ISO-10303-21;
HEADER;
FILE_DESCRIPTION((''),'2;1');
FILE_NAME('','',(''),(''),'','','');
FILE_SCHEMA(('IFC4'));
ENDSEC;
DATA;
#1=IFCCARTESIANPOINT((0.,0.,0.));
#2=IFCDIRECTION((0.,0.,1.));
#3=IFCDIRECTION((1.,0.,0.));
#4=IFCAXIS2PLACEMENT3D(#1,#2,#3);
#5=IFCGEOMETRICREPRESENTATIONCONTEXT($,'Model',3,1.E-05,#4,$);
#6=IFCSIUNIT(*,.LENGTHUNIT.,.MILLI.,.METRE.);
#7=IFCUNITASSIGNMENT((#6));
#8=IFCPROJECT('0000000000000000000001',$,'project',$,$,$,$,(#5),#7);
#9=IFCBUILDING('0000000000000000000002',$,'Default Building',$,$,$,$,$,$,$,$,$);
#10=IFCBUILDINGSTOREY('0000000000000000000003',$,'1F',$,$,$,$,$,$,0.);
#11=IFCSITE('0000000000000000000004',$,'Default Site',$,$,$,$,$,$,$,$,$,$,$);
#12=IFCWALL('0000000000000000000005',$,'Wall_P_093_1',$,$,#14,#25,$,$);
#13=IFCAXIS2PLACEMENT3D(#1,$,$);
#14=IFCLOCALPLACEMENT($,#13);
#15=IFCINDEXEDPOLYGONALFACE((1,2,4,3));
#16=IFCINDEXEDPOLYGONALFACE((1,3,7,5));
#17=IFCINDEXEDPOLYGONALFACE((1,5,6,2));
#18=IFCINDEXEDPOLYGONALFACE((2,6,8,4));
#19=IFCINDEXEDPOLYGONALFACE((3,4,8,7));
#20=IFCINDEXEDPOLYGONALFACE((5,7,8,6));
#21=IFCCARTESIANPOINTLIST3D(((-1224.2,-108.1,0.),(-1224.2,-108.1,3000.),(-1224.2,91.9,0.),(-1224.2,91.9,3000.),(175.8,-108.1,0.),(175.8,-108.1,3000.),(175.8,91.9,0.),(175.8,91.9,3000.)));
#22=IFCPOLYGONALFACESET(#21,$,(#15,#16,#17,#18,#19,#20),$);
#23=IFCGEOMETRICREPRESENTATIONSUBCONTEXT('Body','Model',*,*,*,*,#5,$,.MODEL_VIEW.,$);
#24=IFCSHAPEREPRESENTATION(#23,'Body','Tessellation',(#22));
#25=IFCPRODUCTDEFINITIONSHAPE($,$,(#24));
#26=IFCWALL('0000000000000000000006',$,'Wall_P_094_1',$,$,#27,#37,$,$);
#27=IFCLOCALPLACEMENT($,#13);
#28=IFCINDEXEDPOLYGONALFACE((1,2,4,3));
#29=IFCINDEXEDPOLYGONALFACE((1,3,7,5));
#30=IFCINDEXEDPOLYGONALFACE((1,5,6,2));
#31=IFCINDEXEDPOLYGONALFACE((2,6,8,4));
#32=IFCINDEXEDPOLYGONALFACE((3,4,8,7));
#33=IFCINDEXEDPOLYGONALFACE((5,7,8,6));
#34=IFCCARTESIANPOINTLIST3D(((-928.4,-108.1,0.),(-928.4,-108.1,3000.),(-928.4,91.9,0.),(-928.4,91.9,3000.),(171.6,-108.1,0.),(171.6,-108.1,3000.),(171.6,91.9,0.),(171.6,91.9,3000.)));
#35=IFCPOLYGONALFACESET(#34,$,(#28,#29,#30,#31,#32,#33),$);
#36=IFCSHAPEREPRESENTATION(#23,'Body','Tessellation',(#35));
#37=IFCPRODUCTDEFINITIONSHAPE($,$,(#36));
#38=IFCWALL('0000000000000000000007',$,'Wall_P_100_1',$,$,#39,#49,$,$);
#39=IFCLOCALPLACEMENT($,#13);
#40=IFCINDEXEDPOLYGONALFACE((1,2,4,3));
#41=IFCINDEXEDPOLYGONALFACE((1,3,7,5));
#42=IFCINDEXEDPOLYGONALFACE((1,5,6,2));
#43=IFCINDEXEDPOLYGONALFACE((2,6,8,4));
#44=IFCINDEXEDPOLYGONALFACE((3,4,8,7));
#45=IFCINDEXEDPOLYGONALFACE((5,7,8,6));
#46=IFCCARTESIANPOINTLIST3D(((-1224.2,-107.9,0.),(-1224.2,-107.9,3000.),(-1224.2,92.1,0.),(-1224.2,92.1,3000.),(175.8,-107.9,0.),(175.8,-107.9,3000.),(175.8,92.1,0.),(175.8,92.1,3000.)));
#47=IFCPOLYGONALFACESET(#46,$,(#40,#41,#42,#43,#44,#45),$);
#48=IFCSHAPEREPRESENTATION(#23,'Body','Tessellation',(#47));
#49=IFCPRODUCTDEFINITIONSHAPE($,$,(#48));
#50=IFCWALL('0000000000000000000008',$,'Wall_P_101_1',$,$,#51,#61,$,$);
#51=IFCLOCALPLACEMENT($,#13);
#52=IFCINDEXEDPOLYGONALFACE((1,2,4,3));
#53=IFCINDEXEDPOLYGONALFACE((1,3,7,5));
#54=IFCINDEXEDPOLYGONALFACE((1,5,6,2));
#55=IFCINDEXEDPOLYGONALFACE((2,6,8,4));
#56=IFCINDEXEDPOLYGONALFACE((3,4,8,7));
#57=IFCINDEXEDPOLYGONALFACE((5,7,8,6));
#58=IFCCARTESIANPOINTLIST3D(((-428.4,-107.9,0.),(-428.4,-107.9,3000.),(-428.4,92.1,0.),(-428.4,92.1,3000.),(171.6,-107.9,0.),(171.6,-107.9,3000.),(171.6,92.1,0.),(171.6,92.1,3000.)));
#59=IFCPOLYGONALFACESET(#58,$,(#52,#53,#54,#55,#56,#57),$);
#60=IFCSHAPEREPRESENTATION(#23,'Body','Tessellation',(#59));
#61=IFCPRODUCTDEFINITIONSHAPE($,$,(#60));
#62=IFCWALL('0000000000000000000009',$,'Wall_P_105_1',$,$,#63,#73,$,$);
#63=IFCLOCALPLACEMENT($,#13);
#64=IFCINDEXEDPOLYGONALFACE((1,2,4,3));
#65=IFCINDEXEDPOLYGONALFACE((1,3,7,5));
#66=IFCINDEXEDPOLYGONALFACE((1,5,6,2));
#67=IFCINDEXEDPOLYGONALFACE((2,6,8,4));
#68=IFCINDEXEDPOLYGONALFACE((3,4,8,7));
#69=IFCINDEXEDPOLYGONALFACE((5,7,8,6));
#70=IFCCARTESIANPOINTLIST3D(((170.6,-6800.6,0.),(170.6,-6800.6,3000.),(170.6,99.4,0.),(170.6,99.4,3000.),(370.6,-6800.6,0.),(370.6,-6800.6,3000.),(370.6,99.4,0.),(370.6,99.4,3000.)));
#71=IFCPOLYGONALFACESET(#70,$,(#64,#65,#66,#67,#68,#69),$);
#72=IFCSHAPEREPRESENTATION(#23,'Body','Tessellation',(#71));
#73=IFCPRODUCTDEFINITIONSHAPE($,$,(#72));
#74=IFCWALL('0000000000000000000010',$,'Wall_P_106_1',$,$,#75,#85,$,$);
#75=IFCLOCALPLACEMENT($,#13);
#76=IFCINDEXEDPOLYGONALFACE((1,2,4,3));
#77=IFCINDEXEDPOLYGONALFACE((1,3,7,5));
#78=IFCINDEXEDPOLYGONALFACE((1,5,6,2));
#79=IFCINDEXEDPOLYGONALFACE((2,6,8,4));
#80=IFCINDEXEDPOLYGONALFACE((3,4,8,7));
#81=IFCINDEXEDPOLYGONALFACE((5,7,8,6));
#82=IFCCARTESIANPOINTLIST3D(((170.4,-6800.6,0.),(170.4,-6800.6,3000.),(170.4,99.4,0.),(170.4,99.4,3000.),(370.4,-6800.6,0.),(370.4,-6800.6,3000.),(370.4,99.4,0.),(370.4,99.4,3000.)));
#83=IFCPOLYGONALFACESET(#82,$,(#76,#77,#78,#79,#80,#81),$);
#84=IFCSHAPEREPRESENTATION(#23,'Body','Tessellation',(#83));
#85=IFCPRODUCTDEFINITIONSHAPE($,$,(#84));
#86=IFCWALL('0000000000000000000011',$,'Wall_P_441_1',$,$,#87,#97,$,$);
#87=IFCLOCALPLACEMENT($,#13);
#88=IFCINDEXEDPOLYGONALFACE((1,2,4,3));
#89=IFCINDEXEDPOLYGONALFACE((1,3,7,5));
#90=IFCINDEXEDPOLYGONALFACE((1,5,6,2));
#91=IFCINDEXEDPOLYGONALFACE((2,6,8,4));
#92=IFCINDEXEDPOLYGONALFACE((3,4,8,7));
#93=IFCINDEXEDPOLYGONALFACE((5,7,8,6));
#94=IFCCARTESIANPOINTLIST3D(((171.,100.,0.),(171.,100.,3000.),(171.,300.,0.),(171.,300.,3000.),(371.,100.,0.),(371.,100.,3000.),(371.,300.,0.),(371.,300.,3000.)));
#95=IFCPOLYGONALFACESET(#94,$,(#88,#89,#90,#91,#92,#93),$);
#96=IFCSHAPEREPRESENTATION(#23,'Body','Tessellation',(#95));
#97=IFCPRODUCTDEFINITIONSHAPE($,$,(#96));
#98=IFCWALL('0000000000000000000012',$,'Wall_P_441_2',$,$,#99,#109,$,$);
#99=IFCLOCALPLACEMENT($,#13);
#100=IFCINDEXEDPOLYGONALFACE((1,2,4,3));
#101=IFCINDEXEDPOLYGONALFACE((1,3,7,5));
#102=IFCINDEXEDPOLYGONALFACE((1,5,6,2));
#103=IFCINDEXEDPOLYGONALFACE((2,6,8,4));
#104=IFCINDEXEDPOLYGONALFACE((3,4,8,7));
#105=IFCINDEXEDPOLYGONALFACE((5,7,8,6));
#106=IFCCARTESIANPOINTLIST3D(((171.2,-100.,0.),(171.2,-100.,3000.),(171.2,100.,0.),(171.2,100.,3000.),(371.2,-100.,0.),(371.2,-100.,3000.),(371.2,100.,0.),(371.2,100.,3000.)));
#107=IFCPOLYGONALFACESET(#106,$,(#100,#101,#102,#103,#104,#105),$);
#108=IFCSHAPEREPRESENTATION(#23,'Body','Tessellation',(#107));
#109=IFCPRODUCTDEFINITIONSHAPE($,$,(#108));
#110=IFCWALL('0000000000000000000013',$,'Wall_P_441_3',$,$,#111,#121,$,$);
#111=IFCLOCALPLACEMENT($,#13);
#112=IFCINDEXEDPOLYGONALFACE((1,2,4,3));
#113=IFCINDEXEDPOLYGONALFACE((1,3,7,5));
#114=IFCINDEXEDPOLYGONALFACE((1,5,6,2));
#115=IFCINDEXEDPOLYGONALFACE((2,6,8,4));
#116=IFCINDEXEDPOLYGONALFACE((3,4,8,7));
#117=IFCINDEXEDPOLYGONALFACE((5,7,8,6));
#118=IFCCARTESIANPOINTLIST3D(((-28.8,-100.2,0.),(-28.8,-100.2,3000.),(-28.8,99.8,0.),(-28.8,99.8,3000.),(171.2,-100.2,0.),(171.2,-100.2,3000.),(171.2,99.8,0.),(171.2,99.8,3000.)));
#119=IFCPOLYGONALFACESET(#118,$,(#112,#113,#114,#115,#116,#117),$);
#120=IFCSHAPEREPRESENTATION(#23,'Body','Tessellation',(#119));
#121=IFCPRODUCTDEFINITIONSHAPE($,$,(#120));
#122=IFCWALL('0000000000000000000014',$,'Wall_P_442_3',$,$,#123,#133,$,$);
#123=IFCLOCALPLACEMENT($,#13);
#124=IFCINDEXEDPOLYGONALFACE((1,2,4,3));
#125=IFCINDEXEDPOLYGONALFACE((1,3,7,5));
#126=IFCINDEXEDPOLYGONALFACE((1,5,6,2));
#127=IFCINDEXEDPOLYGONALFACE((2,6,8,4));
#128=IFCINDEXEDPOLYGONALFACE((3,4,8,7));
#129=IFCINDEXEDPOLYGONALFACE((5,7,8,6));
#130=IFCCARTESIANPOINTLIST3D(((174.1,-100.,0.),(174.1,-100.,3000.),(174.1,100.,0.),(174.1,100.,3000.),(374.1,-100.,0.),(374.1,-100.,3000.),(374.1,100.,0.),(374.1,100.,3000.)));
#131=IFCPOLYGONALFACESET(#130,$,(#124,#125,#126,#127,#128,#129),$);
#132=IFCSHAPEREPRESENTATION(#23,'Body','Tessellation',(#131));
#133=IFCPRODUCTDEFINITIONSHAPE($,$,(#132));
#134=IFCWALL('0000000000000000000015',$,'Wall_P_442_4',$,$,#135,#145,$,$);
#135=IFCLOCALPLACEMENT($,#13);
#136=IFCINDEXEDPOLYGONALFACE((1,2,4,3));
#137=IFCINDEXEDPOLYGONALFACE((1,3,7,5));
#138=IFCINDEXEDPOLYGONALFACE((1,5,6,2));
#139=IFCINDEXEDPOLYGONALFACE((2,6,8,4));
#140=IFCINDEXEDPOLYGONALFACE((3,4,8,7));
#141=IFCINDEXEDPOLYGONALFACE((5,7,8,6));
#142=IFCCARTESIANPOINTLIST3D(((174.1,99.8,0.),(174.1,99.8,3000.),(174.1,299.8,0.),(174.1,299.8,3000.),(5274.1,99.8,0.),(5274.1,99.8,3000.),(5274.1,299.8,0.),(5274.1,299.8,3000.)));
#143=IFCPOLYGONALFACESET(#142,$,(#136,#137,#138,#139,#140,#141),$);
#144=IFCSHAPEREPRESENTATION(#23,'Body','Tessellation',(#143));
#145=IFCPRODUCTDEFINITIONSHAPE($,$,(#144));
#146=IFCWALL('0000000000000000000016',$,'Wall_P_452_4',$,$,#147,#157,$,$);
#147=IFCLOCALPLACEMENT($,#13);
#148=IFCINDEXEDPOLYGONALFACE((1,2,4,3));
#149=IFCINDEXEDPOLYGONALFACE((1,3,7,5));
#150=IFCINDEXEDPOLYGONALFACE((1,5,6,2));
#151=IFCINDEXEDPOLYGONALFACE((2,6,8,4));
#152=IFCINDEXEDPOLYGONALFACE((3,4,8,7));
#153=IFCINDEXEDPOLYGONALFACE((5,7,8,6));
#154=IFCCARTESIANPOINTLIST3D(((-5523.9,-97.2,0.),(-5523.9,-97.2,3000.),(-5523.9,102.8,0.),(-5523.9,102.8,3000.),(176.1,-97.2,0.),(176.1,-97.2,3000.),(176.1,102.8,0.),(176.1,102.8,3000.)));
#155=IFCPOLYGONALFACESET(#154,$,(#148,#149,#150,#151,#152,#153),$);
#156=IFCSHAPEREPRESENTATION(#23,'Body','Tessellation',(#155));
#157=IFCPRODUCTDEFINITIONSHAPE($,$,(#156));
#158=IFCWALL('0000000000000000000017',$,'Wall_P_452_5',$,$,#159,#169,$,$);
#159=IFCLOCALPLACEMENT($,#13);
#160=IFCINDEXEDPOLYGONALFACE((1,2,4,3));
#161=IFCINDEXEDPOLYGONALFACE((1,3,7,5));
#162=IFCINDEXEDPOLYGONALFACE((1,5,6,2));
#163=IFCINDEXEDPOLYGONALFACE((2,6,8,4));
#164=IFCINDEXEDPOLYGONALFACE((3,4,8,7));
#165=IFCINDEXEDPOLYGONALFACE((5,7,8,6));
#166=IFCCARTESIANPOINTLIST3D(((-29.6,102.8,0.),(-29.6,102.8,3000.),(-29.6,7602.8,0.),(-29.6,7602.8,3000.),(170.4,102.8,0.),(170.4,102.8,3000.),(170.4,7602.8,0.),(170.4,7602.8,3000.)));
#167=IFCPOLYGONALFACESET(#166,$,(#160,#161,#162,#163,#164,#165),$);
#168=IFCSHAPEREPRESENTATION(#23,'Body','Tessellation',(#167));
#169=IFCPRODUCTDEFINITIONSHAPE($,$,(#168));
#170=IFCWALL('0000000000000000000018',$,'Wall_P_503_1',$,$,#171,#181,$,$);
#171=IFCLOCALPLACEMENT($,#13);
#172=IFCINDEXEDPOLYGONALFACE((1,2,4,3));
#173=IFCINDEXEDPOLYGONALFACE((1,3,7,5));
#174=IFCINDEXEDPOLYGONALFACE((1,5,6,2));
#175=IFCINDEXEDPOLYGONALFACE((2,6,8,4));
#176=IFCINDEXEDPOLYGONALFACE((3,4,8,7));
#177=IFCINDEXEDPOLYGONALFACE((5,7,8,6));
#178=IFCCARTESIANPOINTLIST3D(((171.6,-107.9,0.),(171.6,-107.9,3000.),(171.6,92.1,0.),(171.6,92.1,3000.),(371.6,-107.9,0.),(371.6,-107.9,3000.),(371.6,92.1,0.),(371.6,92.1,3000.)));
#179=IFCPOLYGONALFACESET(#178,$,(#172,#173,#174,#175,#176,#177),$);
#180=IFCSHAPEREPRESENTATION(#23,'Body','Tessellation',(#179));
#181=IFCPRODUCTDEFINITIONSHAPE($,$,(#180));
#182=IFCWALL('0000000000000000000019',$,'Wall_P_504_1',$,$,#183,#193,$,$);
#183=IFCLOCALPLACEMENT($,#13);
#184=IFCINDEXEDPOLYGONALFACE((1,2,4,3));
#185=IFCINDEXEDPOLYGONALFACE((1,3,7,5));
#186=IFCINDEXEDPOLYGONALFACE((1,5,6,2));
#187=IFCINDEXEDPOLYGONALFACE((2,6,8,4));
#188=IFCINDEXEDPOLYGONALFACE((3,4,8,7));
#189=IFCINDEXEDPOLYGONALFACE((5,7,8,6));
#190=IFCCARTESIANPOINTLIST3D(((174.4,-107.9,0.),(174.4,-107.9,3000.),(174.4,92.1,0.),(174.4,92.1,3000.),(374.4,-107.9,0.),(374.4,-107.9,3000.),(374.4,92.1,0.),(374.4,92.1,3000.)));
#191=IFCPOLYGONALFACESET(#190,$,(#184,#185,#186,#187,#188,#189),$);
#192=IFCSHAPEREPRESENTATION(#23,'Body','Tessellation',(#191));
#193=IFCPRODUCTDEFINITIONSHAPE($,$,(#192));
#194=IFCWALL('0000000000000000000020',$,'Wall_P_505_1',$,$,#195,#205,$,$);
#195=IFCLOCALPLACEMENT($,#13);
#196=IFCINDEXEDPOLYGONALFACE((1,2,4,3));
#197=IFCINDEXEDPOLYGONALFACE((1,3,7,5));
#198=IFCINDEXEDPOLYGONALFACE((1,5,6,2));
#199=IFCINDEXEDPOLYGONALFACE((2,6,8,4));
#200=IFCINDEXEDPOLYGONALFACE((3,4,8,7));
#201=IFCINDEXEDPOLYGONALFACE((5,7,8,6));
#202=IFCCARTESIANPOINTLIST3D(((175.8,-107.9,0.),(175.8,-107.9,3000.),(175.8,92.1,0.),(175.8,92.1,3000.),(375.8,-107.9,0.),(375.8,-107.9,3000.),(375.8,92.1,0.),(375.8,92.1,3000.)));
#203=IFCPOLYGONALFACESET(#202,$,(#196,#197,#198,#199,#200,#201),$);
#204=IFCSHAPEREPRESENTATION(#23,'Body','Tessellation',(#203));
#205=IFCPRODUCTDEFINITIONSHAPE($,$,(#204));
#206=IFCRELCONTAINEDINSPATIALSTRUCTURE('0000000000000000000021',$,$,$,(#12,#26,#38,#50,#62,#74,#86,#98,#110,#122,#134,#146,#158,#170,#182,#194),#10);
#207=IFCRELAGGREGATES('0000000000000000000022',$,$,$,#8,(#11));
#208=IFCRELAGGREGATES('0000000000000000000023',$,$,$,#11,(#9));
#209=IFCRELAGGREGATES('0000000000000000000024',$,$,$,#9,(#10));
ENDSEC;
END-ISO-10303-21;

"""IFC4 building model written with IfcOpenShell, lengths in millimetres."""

from ifc_helpers import new_model, si_unit, frame, origin_with_axes, place, context, subcontext, project, spatial, indexed_curve, outline, extrude, element, save


model = new_model("IFC4")

# Units and contexts
model_context = context("Model", 3, precision=1e-05, world=origin_with_axes())
body_context = subcontext(model_context, "Body", "Model", "MODEL_VIEW")
ifc_project = project(units=[si_unit("LENGTHUNIT", "METRE", prefix="MILLI")], contexts=[model_context])

# Site, building, storey
site = spatial("IfcSite", under=ifc_project, Name="Default Site")
building = spatial("IfcBuilding", under=site, Name="Default Building")
storey = spatial("IfcBuildingStorey", under=building, Name="1F", Elevation=0.0)

# Walls
wall_1_placement = place(None, frame((175.8, 91.9, 0.0), z_axis=(0.0, 0.0, 1.0), x_axis=(-1.0, 0.0, 0.0)))
element("IfcWall", 1, at=wall_1_placement, inside=storey, Name="Wall_P_093_1", context=body_context, shape_type="SweptSolid", body=[
    extrude(outline(indexed_curve([(0.0, 0.0), (0.0, 200.0), (1400.0, 200.0), (1400.0, 0.0), (0.0, 0.0)], self_intersect=False)), origin_with_axes(), (0.0, 0.0, 1.0), 3000.0),
])
wall_2_placement = place(None, frame((171.6, 91.9, 0.0), z_axis=(0.0, 0.0, 1.0), x_axis=(-1.0, 0.0, 0.0)))
element("IfcWall", 2, at=wall_2_placement, inside=storey, Name="Wall_P_094_1", context=body_context, shape_type="SweptSolid", body=[
    extrude(outline(indexed_curve([(0.0, 0.0), (0.0, 200.0), (1100.0, 200.0), (1100.0, 0.0), (0.0, 0.0)], self_intersect=False)), origin_with_axes(), (0.0, 0.0, 1.0), 3000.0),
])
wall_3_placement = place(None, frame((175.8, 92.1, 0.0), z_axis=(0.0, 0.0, 1.0), x_axis=(-1.0, 0.0, 0.0)))
element("IfcWall", 3, at=wall_3_placement, inside=storey, Name="Wall_P_100_1", context=body_context, shape_type="SweptSolid", body=[
    extrude(outline(indexed_curve([(0.0, 0.0), (0.0, 200.0), (1400.0, 200.0), (1400.0, 0.0), (0.0, 0.0)], self_intersect=False)), origin_with_axes(), (0.0, 0.0, 1.0), 3000.0),
])
wall_4_placement = place(None, frame((171.6, 92.1, 0.0), z_axis=(0.0, 0.0, 1.0), x_axis=(-1.0, 0.0, 0.0)))
element("IfcWall", 4, at=wall_4_placement, inside=storey, Name="Wall_P_101_1", context=body_context, shape_type="SweptSolid", body=[
    extrude(outline(indexed_curve([(0.0, 0.0), (0.0, 200.0), (600.0, 200.0), (600.0, 0.0), (0.0, 0.0)], self_intersect=False)), origin_with_axes(), (0.0, 0.0, 1.0), 3000.0),
])
for number, where, z_axis, x_axis, name in (
    (5, (170.6, 99.4, 0.0), (0.0, 0.0, 1.0), (0.0, -1.0, 0.0), "Wall_P_105_1"),
    (6, (170.4, 99.4, 0.0), (0.0, 0.0, 1.0), (0.0, -1.0, 0.0), "Wall_P_106_1"),
):
    element("IfcWall", number, at=place(None, frame(where, z_axis=z_axis, x_axis=x_axis)), inside=storey, Name=name, context=body_context, shape_type="SweptSolid", body=[
        extrude(outline(indexed_curve([(0.0, 0.0), (0.0, 200.0), (6900.0, 200.0), (6900.0, 0.0), (0.0, 0.0)], self_intersect=False)), origin_with_axes(), (0.0, 0.0, 1.0), 3000.0),
    ])
wall_5_placement = place(None, frame((171.0, 100.0, 0.0), z_axis=(0.0, 0.0, 1.0), x_axis=(1.0, 0.0, 0.0)))
element("IfcWall", 7, at=wall_5_placement, inside=storey, Name="Wall_P_441_1", context=body_context, shape_type="SweptSolid", body=[
    extrude(outline(indexed_curve([(0.0, 0.0), (0.0, 200.0), (200.0, 200.0), (200.0, 0.0), (0.0, 0.0)], self_intersect=False)), origin_with_axes(), (0.0, 0.0, 1.0), 3000.0),
])
wall_6_placement = place(None, frame((171.2, 100.0, 0.0), z_axis=(0.0, 0.0, 1.0), x_axis=(0.0, -1.0, 0.0)))
element("IfcWall", 8, at=wall_6_placement, inside=storey, Name="Wall_P_441_2", context=body_context, shape_type="SweptSolid", body=[
    extrude(outline(indexed_curve([(0.0, 0.0), (0.0, 200.0), (200.0, 200.0), (200.0, 0.0), (0.0, 0.0)], self_intersect=False)), origin_with_axes(), (0.0, 0.0, 1.0), 3000.0),
])
wall_7_placement = place(None, frame((171.2, 99.8, 0.0), z_axis=(0.0, 0.0, 1.0), x_axis=(-1.0, 0.0, 0.0)))
element("IfcWall", 9, at=wall_7_placement, inside=storey, Name="Wall_P_441_3", context=body_context, shape_type="SweptSolid", body=[
    extrude(outline(indexed_curve([(0.0, 0.0), (0.0, 200.0), (200.0, 200.0), (200.0, 0.0), (0.0, 0.0)], self_intersect=False)), origin_with_axes(), (0.0, 0.0, 1.0), 3000.0),
])
wall_8_placement = place(None, frame((174.1, 100.0, 0.0), z_axis=(0.0, 0.0, 1.0), x_axis=(0.0, -1.0, 0.0)))
element("IfcWall", 10, at=wall_8_placement, inside=storey, Name="Wall_P_442_3", context=body_context, shape_type="SweptSolid", body=[
    extrude(outline(indexed_curve([(0.0, 0.0), (0.0, 200.0), (200.0, 200.0), (200.0, 0.0), (0.0, 0.0)], self_intersect=False)), origin_with_axes(), (0.0, 0.0, 1.0), 3000.0),
])
wall_9_placement = place(None, frame((174.1, 99.8, 0.0), z_axis=(0.0, 0.0, 1.0), x_axis=(1.0, 0.0, 0.0)))
element("IfcWall", 11, at=wall_9_placement, inside=storey, Name="Wall_P_442_4", context=body_context, shape_type="SweptSolid", body=[
    extrude(outline(indexed_curve([(0.0, 0.0), (0.0, 200.0), (5100.0, 200.0), (5100.0, 0.0), (0.0, 0.0)], self_intersect=False)), origin_with_axes(), (0.0, 0.0, 1.0), 3000.0),
])
wall_10_placement = place(None, frame((176.1, 102.8, 0.0), z_axis=(0.0, 0.0, 1.0), x_axis=(-1.0, 0.0, 0.0)))
element("IfcWall", 12, at=wall_10_placement, inside=storey, Name="Wall_P_452_4", context=body_context, shape_type="SweptSolid", body=[
    extrude(outline(indexed_curve([(0.0, 0.0), (0.0, 200.0), (5700.0, 200.0), (5700.0, 0.0), (0.0, 0.0)], self_intersect=False)), origin_with_axes(), (0.0, 0.0, 1.0), 3000.0),
])
wall_11_placement = place(None, frame((170.4, 102.8, 0.0), z_axis=(0.0, 0.0, 1.0), x_axis=(0.0, 1.0, 0.0)))
element("IfcWall", 13, at=wall_11_placement, inside=storey, Name="Wall_P_452_5", context=body_context, shape_type="SweptSolid", body=[
    extrude(outline(indexed_curve([(0.0, 0.0), (0.0, 200.0), (7500.0, 200.0), (7500.0, 0.0), (0.0, 0.0)], self_intersect=False)), origin_with_axes(), (0.0, 0.0, 1.0), 3000.0),
])
wall_12_placement = place(None, frame((171.6, 92.1, 0.0), z_axis=(0.0, 0.0, 1.0), x_axis=(0.0, -1.0, 0.0)))
element("IfcWall", 14, at=wall_12_placement, inside=storey, Name="Wall_P_503_1", context=body_context, shape_type="SweptSolid", body=[
    extrude(outline(indexed_curve([(0.0, 0.0), (0.0, 200.0), (200.0, 200.0), (200.0, 0.0), (0.0, 0.0)], self_intersect=False)), origin_with_axes(), (0.0, 0.0, 1.0), 3000.0),
])
wall_13_placement = place(None, frame((174.4, 92.1, 0.0), z_axis=(0.0, 0.0, 1.0), x_axis=(0.0, -1.0, 0.0)))
element("IfcWall", 15, at=wall_13_placement, inside=storey, Name="Wall_P_504_1", context=body_context, shape_type="SweptSolid", body=[
    extrude(outline(indexed_curve([(0.0, 0.0), (0.0, 200.0), (200.0, 200.0), (200.0, 0.0), (0.0, 0.0)], self_intersect=False)), origin_with_axes(), (0.0, 0.0, 1.0), 3000.0),
])
wall_14_placement = place(None, frame((175.8, 92.1, 0.0), z_axis=(0.0, 0.0, 1.0), x_axis=(0.0, -1.0, 0.0)))
element("IfcWall", 16, at=wall_14_placement, inside=storey, Name="Wall_P_505_1", context=body_context, shape_type="SweptSolid", body=[
    extrude(outline(indexed_curve([(0.0, 0.0), (0.0, 200.0), (200.0, 200.0), (200.0, 0.0), (0.0, 0.0)], self_intersect=False)), origin_with_axes(), (0.0, 0.0, 1.0), 3000.0),
])

save(model, "model.ifc")
